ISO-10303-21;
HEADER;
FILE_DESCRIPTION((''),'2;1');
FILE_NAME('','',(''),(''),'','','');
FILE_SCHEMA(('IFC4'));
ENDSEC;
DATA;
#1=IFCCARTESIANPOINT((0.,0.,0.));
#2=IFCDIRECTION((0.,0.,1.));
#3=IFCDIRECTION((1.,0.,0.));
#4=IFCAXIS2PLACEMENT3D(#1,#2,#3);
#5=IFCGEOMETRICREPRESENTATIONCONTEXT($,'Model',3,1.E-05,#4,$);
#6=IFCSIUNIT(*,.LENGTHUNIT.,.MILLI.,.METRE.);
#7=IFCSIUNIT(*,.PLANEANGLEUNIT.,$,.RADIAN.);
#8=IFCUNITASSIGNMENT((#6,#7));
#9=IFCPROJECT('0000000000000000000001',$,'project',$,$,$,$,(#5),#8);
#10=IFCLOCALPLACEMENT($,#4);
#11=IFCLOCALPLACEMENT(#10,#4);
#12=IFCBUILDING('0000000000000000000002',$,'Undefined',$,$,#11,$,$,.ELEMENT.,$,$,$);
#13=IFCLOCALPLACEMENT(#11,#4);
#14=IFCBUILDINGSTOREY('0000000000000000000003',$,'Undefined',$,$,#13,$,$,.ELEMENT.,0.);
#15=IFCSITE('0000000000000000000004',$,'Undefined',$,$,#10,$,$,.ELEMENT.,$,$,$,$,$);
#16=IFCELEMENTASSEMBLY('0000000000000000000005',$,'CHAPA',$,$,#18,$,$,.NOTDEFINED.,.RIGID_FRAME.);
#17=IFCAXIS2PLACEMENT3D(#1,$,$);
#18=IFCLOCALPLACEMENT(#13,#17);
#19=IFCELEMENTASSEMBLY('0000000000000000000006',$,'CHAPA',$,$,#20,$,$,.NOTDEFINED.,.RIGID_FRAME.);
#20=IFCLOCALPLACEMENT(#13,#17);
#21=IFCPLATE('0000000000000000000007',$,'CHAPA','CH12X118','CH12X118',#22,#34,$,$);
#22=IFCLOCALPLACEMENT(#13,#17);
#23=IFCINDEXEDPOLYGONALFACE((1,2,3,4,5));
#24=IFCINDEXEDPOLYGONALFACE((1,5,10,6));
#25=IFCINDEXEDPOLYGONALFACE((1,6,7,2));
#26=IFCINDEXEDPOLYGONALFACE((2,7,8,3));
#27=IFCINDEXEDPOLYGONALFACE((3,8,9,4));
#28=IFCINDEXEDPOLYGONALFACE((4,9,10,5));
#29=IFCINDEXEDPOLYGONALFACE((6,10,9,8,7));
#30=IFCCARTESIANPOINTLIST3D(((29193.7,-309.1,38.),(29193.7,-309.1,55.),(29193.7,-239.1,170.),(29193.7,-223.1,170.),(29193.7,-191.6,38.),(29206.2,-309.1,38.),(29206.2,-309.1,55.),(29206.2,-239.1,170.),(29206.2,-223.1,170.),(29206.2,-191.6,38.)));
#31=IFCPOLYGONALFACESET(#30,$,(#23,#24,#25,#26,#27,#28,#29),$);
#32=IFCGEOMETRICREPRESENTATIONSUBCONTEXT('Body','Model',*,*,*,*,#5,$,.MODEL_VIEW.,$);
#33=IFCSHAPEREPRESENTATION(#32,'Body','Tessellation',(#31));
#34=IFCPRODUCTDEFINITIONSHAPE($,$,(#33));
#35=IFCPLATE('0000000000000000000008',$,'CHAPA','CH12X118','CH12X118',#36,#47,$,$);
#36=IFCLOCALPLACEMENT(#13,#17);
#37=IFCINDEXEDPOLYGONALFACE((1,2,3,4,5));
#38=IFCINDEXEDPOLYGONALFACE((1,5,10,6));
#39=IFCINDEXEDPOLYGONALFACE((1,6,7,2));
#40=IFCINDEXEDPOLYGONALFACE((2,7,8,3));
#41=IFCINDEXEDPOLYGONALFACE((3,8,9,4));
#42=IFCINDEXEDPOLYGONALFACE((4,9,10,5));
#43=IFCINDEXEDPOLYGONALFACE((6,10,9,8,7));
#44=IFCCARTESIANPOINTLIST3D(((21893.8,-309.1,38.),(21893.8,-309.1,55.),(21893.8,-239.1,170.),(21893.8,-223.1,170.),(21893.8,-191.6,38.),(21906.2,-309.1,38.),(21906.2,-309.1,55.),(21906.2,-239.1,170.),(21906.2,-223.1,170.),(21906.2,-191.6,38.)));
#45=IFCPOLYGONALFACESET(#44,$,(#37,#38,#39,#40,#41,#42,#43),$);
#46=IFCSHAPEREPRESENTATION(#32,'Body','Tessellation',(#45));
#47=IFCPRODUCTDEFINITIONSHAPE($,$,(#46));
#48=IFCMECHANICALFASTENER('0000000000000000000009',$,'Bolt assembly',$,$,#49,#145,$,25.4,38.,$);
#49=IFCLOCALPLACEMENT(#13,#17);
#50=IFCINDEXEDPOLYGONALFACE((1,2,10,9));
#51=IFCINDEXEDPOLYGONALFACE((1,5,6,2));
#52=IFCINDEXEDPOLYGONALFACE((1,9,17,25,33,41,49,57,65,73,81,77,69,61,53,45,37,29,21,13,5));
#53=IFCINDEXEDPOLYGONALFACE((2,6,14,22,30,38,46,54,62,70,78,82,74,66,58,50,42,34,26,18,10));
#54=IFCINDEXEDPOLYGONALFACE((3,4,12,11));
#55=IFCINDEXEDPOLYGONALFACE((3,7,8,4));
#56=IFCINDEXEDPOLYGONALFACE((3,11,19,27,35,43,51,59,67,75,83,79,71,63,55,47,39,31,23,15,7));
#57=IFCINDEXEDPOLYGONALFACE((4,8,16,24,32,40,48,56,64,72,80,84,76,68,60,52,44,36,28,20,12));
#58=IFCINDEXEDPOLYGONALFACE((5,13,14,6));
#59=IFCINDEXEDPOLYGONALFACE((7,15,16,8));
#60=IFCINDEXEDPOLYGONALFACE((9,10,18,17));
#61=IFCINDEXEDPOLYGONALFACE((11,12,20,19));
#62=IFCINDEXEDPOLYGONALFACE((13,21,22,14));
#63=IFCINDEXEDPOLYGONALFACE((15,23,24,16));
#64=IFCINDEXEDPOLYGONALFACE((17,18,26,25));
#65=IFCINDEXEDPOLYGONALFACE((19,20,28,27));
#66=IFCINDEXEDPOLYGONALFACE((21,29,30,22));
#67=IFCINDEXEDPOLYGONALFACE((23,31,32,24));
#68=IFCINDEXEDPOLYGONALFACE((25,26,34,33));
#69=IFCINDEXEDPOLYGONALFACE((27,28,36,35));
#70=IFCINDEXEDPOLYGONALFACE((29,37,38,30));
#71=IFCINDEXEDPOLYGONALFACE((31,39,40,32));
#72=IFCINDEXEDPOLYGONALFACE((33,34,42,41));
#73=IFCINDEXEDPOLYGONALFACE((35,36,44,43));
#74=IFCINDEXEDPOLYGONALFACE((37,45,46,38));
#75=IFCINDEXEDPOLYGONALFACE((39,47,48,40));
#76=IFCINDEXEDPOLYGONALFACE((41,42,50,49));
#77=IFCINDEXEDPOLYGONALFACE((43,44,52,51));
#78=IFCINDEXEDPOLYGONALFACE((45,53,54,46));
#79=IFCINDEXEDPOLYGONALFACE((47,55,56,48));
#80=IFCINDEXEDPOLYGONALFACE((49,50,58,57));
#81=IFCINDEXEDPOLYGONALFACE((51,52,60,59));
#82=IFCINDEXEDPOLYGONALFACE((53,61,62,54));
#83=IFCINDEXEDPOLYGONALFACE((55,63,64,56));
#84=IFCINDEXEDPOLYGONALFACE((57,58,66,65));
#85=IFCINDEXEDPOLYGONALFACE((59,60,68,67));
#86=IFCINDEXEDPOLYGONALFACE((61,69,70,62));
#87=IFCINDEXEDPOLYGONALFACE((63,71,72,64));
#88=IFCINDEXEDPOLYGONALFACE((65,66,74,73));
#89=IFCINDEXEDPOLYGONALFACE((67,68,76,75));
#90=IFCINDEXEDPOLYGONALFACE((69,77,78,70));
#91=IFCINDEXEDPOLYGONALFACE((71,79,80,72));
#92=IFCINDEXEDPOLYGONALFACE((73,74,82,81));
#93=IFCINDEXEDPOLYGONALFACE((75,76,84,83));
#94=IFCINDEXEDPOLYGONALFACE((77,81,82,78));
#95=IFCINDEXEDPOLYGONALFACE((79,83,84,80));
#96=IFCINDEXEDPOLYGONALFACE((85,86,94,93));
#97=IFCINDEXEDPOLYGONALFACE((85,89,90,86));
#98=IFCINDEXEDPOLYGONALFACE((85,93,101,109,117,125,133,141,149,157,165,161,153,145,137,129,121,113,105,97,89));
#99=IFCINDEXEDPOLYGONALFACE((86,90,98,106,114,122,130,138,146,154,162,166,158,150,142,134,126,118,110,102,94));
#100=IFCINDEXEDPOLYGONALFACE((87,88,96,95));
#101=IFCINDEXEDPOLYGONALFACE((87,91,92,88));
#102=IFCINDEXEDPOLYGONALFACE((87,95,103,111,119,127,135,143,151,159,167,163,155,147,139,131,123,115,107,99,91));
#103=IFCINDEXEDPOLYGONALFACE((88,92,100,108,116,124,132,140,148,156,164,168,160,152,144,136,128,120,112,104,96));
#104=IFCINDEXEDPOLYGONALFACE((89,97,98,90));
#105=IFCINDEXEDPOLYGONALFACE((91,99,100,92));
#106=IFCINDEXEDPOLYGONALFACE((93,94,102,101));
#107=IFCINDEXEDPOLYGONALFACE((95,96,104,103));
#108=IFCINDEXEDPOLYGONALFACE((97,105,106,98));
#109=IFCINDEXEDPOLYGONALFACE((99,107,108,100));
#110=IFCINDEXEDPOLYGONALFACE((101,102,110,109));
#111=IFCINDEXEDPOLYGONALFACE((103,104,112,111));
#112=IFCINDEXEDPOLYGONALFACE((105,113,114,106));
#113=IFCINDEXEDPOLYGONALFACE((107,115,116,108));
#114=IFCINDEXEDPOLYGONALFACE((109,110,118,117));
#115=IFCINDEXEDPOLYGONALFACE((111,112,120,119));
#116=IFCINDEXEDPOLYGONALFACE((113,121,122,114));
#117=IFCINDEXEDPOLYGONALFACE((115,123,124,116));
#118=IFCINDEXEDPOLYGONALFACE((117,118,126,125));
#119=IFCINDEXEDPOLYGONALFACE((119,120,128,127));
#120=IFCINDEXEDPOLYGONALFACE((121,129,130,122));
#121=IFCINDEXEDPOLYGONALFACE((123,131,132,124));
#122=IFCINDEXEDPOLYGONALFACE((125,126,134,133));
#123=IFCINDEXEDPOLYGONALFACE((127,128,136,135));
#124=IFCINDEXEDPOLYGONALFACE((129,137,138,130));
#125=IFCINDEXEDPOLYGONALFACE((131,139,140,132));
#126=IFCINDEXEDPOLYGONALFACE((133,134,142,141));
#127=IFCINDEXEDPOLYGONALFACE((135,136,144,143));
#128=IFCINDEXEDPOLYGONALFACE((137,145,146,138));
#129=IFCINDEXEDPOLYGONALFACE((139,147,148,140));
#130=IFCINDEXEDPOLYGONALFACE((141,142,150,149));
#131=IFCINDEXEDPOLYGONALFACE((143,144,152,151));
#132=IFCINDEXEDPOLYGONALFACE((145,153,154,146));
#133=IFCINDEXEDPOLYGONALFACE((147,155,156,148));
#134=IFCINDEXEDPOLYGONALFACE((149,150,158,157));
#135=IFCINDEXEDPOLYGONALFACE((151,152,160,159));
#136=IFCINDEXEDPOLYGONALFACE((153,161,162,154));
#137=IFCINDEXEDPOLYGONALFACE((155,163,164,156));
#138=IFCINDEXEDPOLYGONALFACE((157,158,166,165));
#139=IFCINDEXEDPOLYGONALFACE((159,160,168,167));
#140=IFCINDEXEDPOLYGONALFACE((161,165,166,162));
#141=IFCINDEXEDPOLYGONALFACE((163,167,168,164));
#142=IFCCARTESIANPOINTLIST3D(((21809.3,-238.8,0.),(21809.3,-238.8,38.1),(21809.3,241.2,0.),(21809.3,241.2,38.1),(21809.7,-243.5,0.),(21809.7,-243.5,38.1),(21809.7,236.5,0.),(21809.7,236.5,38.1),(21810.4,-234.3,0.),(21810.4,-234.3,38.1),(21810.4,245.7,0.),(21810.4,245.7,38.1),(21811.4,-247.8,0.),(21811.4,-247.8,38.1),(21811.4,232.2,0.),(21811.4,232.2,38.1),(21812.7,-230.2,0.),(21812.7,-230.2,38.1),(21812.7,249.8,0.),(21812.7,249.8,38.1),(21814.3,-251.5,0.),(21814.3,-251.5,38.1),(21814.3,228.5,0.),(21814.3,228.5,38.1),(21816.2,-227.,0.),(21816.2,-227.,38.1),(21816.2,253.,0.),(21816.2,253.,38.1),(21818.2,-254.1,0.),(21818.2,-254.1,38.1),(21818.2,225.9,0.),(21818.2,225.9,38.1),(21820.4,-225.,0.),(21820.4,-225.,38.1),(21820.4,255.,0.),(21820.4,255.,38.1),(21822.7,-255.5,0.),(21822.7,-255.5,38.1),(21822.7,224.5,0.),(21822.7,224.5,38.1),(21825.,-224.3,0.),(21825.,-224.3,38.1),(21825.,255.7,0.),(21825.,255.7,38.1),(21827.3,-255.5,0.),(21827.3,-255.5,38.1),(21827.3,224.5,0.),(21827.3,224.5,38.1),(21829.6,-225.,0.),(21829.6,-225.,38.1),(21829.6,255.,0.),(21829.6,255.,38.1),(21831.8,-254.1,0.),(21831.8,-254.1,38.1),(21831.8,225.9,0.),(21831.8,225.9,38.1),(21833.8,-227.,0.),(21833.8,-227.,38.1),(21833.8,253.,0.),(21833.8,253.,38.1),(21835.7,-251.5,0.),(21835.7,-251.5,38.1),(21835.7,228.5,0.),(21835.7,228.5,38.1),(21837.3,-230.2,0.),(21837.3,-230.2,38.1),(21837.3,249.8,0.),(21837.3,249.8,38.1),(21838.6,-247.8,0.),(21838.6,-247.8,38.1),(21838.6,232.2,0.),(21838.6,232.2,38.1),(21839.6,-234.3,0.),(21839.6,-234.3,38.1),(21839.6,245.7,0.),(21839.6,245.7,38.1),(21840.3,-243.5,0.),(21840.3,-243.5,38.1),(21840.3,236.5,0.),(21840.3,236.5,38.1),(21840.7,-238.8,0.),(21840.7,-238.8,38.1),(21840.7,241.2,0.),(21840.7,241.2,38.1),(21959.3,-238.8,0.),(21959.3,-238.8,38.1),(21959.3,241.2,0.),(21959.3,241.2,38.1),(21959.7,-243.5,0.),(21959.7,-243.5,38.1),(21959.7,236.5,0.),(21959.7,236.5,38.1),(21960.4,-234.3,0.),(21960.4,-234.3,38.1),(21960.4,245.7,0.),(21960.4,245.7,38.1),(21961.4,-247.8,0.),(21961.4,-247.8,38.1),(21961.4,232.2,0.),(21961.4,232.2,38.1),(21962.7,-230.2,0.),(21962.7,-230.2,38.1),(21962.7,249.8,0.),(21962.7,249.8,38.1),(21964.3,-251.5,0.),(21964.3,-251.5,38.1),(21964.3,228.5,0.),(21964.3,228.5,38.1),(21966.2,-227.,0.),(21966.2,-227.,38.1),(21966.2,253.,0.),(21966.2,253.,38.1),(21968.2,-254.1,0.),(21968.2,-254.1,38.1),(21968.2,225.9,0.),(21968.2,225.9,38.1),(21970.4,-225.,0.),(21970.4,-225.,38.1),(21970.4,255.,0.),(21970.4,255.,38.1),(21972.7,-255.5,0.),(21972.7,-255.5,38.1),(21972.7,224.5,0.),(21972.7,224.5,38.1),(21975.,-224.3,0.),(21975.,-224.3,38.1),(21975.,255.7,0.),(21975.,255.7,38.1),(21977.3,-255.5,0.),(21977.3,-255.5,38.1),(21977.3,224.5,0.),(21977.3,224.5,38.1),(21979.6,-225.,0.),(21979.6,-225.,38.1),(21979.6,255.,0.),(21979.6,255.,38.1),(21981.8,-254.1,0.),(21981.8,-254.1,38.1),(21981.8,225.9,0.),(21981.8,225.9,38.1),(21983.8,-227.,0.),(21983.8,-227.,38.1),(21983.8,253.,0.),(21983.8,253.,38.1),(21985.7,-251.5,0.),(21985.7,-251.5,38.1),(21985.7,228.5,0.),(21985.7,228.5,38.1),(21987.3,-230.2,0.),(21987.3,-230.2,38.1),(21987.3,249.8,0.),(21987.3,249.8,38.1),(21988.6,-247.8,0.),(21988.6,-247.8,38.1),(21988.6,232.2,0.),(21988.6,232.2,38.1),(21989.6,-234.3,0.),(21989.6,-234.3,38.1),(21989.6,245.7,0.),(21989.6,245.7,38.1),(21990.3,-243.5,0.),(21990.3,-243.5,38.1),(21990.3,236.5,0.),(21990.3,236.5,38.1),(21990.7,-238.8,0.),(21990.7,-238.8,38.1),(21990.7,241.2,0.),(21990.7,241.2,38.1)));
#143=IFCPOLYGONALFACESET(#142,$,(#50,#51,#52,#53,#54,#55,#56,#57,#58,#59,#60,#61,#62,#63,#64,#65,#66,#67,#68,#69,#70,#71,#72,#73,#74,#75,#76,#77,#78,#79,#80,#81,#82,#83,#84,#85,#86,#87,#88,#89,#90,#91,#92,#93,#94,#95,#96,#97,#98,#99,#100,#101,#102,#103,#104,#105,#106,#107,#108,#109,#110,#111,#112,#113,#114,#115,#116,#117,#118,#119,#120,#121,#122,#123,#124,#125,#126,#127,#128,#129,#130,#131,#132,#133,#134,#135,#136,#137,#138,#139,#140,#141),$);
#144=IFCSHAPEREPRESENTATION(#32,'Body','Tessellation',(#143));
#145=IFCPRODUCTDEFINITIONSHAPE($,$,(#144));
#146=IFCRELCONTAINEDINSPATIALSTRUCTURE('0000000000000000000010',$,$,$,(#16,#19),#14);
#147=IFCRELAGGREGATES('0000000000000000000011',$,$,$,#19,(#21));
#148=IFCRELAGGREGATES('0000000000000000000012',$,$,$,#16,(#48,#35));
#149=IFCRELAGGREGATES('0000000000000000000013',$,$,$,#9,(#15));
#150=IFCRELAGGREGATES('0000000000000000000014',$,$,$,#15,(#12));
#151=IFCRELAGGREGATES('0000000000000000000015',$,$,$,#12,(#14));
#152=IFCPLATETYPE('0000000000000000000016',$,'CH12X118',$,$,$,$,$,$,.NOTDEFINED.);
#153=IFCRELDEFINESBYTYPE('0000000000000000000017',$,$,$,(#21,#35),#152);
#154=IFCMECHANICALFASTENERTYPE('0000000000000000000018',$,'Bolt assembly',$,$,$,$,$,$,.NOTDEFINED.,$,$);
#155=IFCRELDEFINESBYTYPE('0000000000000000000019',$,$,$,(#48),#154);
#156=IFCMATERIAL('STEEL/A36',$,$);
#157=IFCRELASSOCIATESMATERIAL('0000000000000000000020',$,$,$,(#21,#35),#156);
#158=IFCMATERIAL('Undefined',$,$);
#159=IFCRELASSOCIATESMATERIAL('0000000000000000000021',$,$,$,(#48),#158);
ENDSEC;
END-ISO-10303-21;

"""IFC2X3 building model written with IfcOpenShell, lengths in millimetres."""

from ifc_helpers import new_model, si_unit, frame, origin_with_axes, origin_2d_with_axis, place, context, subcontext, project, spatial, polyline, circle, outline, extrude, source, transform, mapped, material, type_object, element, aggregate, save


model = new_model("IFC2X3")

# Units and contexts
model_context = context("Model", 3, precision=1e-05, world=origin_with_axes())
body_context = subcontext(model_context, "Body", "Model", "MODEL_VIEW")
ifc_project = project(units=[si_unit("LENGTHUNIT", "METRE", prefix="MILLI"), si_unit("PLANEANGLEUNIT", "RADIAN")], contexts=[model_context])

# Site, building, storey
site_placement = place(None, origin_with_axes())
site = spatial("IfcSite", under=ifc_project, at=site_placement, Name="Undefined", CompositionType="ELEMENT")
building_placement = place(site_placement, origin_with_axes())
building = spatial("IfcBuilding", under=site, at=building_placement, Name="Undefined", CompositionType="ELEMENT")
storey_placement = place(building_placement, origin_with_axes())
storey = spatial("IfcBuildingStorey", under=building, at=storey_placement, Name="Undefined", CompositionType="ELEMENT", Elevation=0.0)

# Element assembly
assembly_1_placement = place(storey_placement, origin_with_axes())
assembly_1 = element("IfcElementAssembly", 1, at=assembly_1_placement, inside=storey, Name="CHAPA", AssemblyPlace="NOTDEFINED", PredefinedType="RIGID_FRAME")
ifc_material_1 = material(Name="STEEL/A36")

# Element assembly, plate
assembly_2_placement = place(storey_placement, origin_with_axes())
assembly_2 = element("IfcElementAssembly", 2, at=assembly_2_placement, inside=storey, Name="CHAPA", AssemblyPlace="NOTDEFINED", PredefinedType="RIGID_FRAME")
plate_type_1 = type_object("IfcPlateType", Name="CH12X118", PredefinedType="NOTDEFINED")
plate_1_placement = place(assembly_2_placement, frame((29200.0, -309.1, 38.0), z_axis=(1.0, 0.0, 0.0), x_axis=(0.0, 1.0, 0.0)))
plate_1 = element("IfcPlate", 3, at=plate_1_placement, type_object=plate_type_1, material=ifc_material_1, Name="CHAPA", Description="CH12X118", ObjectType="CH12X118", context=body_context, shape_type="SweptSolid", body=[
    extrude(outline(polyline([(0.0, 0.0), (117.5, 0.0), (85.9, 132.0), (70.0, 132.0), (0.0, 17.0), (0.0, 0.0)])), frame((0.0, 0.0, -6.2), z_axis=(0.0, 0.0, 1.0), x_axis=(1.0, 0.0, 0.0)), (0.0, 0.0, 1.0), 12.5),
])
aggregate(assembly_2, [plate_1])

# Plate
plate_2_placement = place(assembly_1_placement, frame((21900.0, -309.1, 38.0), z_axis=(1.0, 0.0, 0.0), x_axis=(0.0, 1.0, 0.0)))
plate_2 = element("IfcPlate", 4, at=plate_2_placement, type_object=plate_type_1, material=ifc_material_1, Name="CHAPA", Description="CH12X118", ObjectType="CH12X118", context=body_context, shape_type="SweptSolid", body=[
    extrude(outline(polyline([(0.0, 0.0), (117.5, 0.0), (85.9, 132.0), (70.0, 132.0), (0.0, 17.0), (0.0, 0.0)])), frame((0.0, 0.0, -6.2), z_axis=(0.0, 0.0, 1.0), x_axis=(1.0, 0.0, 0.0)), (0.0, 0.0, 1.0), 12.5),
])

# Shared definitions
ifc_material_2 = material(Name="Undefined")
mechanical_fastener_type = type_object("IfcMechanicalFastenerType", Name="Bolt assembly")

# Mechanical fastener
shared_shape_1 = source(origin_with_axes(), body_context, "Body", "SweptSolid", [
    extrude(circle(Radius=15.7, at=origin_2d_with_axis()), frame((0.0, -38.0, 0.0), z_axis=(0.0, 1.0, 0.0), x_axis=(1.0, 0.0, 0.0)), (0.0, 0.0, 1.0), 38.1),
])
mechanical_fastener_1_placement = place(assembly_1_placement, frame((21900.0, -240.0, 38.0), z_axis=(1.0, 0.0, 0.0), x_axis=(0.0, 1.0, 0.0)))
mechanical_fastener_1 = element("IfcMechanicalFastener", 5, at=mechanical_fastener_1_placement, type_object=mechanical_fastener_type, material=ifc_material_2, Name="Bolt assembly", NominalDiameter=25.4, NominalLength=38.0, context=body_context, shape_type="MappedRepresentation", body=[
    mapped(shared_shape_1, transform((0.0, 0.0, -75.0))),
    mapped(shared_shape_1, transform((0.0, 0.0, 75.0))),
    mapped(shared_shape_1, transform((480.0, 0.0, -75.0))),
    mapped(shared_shape_1, transform((480.0, 0.0, 75.0))),
])
aggregate(assembly_1, [mechanical_fastener_1, plate_2])

save(model, "model.ifc")
